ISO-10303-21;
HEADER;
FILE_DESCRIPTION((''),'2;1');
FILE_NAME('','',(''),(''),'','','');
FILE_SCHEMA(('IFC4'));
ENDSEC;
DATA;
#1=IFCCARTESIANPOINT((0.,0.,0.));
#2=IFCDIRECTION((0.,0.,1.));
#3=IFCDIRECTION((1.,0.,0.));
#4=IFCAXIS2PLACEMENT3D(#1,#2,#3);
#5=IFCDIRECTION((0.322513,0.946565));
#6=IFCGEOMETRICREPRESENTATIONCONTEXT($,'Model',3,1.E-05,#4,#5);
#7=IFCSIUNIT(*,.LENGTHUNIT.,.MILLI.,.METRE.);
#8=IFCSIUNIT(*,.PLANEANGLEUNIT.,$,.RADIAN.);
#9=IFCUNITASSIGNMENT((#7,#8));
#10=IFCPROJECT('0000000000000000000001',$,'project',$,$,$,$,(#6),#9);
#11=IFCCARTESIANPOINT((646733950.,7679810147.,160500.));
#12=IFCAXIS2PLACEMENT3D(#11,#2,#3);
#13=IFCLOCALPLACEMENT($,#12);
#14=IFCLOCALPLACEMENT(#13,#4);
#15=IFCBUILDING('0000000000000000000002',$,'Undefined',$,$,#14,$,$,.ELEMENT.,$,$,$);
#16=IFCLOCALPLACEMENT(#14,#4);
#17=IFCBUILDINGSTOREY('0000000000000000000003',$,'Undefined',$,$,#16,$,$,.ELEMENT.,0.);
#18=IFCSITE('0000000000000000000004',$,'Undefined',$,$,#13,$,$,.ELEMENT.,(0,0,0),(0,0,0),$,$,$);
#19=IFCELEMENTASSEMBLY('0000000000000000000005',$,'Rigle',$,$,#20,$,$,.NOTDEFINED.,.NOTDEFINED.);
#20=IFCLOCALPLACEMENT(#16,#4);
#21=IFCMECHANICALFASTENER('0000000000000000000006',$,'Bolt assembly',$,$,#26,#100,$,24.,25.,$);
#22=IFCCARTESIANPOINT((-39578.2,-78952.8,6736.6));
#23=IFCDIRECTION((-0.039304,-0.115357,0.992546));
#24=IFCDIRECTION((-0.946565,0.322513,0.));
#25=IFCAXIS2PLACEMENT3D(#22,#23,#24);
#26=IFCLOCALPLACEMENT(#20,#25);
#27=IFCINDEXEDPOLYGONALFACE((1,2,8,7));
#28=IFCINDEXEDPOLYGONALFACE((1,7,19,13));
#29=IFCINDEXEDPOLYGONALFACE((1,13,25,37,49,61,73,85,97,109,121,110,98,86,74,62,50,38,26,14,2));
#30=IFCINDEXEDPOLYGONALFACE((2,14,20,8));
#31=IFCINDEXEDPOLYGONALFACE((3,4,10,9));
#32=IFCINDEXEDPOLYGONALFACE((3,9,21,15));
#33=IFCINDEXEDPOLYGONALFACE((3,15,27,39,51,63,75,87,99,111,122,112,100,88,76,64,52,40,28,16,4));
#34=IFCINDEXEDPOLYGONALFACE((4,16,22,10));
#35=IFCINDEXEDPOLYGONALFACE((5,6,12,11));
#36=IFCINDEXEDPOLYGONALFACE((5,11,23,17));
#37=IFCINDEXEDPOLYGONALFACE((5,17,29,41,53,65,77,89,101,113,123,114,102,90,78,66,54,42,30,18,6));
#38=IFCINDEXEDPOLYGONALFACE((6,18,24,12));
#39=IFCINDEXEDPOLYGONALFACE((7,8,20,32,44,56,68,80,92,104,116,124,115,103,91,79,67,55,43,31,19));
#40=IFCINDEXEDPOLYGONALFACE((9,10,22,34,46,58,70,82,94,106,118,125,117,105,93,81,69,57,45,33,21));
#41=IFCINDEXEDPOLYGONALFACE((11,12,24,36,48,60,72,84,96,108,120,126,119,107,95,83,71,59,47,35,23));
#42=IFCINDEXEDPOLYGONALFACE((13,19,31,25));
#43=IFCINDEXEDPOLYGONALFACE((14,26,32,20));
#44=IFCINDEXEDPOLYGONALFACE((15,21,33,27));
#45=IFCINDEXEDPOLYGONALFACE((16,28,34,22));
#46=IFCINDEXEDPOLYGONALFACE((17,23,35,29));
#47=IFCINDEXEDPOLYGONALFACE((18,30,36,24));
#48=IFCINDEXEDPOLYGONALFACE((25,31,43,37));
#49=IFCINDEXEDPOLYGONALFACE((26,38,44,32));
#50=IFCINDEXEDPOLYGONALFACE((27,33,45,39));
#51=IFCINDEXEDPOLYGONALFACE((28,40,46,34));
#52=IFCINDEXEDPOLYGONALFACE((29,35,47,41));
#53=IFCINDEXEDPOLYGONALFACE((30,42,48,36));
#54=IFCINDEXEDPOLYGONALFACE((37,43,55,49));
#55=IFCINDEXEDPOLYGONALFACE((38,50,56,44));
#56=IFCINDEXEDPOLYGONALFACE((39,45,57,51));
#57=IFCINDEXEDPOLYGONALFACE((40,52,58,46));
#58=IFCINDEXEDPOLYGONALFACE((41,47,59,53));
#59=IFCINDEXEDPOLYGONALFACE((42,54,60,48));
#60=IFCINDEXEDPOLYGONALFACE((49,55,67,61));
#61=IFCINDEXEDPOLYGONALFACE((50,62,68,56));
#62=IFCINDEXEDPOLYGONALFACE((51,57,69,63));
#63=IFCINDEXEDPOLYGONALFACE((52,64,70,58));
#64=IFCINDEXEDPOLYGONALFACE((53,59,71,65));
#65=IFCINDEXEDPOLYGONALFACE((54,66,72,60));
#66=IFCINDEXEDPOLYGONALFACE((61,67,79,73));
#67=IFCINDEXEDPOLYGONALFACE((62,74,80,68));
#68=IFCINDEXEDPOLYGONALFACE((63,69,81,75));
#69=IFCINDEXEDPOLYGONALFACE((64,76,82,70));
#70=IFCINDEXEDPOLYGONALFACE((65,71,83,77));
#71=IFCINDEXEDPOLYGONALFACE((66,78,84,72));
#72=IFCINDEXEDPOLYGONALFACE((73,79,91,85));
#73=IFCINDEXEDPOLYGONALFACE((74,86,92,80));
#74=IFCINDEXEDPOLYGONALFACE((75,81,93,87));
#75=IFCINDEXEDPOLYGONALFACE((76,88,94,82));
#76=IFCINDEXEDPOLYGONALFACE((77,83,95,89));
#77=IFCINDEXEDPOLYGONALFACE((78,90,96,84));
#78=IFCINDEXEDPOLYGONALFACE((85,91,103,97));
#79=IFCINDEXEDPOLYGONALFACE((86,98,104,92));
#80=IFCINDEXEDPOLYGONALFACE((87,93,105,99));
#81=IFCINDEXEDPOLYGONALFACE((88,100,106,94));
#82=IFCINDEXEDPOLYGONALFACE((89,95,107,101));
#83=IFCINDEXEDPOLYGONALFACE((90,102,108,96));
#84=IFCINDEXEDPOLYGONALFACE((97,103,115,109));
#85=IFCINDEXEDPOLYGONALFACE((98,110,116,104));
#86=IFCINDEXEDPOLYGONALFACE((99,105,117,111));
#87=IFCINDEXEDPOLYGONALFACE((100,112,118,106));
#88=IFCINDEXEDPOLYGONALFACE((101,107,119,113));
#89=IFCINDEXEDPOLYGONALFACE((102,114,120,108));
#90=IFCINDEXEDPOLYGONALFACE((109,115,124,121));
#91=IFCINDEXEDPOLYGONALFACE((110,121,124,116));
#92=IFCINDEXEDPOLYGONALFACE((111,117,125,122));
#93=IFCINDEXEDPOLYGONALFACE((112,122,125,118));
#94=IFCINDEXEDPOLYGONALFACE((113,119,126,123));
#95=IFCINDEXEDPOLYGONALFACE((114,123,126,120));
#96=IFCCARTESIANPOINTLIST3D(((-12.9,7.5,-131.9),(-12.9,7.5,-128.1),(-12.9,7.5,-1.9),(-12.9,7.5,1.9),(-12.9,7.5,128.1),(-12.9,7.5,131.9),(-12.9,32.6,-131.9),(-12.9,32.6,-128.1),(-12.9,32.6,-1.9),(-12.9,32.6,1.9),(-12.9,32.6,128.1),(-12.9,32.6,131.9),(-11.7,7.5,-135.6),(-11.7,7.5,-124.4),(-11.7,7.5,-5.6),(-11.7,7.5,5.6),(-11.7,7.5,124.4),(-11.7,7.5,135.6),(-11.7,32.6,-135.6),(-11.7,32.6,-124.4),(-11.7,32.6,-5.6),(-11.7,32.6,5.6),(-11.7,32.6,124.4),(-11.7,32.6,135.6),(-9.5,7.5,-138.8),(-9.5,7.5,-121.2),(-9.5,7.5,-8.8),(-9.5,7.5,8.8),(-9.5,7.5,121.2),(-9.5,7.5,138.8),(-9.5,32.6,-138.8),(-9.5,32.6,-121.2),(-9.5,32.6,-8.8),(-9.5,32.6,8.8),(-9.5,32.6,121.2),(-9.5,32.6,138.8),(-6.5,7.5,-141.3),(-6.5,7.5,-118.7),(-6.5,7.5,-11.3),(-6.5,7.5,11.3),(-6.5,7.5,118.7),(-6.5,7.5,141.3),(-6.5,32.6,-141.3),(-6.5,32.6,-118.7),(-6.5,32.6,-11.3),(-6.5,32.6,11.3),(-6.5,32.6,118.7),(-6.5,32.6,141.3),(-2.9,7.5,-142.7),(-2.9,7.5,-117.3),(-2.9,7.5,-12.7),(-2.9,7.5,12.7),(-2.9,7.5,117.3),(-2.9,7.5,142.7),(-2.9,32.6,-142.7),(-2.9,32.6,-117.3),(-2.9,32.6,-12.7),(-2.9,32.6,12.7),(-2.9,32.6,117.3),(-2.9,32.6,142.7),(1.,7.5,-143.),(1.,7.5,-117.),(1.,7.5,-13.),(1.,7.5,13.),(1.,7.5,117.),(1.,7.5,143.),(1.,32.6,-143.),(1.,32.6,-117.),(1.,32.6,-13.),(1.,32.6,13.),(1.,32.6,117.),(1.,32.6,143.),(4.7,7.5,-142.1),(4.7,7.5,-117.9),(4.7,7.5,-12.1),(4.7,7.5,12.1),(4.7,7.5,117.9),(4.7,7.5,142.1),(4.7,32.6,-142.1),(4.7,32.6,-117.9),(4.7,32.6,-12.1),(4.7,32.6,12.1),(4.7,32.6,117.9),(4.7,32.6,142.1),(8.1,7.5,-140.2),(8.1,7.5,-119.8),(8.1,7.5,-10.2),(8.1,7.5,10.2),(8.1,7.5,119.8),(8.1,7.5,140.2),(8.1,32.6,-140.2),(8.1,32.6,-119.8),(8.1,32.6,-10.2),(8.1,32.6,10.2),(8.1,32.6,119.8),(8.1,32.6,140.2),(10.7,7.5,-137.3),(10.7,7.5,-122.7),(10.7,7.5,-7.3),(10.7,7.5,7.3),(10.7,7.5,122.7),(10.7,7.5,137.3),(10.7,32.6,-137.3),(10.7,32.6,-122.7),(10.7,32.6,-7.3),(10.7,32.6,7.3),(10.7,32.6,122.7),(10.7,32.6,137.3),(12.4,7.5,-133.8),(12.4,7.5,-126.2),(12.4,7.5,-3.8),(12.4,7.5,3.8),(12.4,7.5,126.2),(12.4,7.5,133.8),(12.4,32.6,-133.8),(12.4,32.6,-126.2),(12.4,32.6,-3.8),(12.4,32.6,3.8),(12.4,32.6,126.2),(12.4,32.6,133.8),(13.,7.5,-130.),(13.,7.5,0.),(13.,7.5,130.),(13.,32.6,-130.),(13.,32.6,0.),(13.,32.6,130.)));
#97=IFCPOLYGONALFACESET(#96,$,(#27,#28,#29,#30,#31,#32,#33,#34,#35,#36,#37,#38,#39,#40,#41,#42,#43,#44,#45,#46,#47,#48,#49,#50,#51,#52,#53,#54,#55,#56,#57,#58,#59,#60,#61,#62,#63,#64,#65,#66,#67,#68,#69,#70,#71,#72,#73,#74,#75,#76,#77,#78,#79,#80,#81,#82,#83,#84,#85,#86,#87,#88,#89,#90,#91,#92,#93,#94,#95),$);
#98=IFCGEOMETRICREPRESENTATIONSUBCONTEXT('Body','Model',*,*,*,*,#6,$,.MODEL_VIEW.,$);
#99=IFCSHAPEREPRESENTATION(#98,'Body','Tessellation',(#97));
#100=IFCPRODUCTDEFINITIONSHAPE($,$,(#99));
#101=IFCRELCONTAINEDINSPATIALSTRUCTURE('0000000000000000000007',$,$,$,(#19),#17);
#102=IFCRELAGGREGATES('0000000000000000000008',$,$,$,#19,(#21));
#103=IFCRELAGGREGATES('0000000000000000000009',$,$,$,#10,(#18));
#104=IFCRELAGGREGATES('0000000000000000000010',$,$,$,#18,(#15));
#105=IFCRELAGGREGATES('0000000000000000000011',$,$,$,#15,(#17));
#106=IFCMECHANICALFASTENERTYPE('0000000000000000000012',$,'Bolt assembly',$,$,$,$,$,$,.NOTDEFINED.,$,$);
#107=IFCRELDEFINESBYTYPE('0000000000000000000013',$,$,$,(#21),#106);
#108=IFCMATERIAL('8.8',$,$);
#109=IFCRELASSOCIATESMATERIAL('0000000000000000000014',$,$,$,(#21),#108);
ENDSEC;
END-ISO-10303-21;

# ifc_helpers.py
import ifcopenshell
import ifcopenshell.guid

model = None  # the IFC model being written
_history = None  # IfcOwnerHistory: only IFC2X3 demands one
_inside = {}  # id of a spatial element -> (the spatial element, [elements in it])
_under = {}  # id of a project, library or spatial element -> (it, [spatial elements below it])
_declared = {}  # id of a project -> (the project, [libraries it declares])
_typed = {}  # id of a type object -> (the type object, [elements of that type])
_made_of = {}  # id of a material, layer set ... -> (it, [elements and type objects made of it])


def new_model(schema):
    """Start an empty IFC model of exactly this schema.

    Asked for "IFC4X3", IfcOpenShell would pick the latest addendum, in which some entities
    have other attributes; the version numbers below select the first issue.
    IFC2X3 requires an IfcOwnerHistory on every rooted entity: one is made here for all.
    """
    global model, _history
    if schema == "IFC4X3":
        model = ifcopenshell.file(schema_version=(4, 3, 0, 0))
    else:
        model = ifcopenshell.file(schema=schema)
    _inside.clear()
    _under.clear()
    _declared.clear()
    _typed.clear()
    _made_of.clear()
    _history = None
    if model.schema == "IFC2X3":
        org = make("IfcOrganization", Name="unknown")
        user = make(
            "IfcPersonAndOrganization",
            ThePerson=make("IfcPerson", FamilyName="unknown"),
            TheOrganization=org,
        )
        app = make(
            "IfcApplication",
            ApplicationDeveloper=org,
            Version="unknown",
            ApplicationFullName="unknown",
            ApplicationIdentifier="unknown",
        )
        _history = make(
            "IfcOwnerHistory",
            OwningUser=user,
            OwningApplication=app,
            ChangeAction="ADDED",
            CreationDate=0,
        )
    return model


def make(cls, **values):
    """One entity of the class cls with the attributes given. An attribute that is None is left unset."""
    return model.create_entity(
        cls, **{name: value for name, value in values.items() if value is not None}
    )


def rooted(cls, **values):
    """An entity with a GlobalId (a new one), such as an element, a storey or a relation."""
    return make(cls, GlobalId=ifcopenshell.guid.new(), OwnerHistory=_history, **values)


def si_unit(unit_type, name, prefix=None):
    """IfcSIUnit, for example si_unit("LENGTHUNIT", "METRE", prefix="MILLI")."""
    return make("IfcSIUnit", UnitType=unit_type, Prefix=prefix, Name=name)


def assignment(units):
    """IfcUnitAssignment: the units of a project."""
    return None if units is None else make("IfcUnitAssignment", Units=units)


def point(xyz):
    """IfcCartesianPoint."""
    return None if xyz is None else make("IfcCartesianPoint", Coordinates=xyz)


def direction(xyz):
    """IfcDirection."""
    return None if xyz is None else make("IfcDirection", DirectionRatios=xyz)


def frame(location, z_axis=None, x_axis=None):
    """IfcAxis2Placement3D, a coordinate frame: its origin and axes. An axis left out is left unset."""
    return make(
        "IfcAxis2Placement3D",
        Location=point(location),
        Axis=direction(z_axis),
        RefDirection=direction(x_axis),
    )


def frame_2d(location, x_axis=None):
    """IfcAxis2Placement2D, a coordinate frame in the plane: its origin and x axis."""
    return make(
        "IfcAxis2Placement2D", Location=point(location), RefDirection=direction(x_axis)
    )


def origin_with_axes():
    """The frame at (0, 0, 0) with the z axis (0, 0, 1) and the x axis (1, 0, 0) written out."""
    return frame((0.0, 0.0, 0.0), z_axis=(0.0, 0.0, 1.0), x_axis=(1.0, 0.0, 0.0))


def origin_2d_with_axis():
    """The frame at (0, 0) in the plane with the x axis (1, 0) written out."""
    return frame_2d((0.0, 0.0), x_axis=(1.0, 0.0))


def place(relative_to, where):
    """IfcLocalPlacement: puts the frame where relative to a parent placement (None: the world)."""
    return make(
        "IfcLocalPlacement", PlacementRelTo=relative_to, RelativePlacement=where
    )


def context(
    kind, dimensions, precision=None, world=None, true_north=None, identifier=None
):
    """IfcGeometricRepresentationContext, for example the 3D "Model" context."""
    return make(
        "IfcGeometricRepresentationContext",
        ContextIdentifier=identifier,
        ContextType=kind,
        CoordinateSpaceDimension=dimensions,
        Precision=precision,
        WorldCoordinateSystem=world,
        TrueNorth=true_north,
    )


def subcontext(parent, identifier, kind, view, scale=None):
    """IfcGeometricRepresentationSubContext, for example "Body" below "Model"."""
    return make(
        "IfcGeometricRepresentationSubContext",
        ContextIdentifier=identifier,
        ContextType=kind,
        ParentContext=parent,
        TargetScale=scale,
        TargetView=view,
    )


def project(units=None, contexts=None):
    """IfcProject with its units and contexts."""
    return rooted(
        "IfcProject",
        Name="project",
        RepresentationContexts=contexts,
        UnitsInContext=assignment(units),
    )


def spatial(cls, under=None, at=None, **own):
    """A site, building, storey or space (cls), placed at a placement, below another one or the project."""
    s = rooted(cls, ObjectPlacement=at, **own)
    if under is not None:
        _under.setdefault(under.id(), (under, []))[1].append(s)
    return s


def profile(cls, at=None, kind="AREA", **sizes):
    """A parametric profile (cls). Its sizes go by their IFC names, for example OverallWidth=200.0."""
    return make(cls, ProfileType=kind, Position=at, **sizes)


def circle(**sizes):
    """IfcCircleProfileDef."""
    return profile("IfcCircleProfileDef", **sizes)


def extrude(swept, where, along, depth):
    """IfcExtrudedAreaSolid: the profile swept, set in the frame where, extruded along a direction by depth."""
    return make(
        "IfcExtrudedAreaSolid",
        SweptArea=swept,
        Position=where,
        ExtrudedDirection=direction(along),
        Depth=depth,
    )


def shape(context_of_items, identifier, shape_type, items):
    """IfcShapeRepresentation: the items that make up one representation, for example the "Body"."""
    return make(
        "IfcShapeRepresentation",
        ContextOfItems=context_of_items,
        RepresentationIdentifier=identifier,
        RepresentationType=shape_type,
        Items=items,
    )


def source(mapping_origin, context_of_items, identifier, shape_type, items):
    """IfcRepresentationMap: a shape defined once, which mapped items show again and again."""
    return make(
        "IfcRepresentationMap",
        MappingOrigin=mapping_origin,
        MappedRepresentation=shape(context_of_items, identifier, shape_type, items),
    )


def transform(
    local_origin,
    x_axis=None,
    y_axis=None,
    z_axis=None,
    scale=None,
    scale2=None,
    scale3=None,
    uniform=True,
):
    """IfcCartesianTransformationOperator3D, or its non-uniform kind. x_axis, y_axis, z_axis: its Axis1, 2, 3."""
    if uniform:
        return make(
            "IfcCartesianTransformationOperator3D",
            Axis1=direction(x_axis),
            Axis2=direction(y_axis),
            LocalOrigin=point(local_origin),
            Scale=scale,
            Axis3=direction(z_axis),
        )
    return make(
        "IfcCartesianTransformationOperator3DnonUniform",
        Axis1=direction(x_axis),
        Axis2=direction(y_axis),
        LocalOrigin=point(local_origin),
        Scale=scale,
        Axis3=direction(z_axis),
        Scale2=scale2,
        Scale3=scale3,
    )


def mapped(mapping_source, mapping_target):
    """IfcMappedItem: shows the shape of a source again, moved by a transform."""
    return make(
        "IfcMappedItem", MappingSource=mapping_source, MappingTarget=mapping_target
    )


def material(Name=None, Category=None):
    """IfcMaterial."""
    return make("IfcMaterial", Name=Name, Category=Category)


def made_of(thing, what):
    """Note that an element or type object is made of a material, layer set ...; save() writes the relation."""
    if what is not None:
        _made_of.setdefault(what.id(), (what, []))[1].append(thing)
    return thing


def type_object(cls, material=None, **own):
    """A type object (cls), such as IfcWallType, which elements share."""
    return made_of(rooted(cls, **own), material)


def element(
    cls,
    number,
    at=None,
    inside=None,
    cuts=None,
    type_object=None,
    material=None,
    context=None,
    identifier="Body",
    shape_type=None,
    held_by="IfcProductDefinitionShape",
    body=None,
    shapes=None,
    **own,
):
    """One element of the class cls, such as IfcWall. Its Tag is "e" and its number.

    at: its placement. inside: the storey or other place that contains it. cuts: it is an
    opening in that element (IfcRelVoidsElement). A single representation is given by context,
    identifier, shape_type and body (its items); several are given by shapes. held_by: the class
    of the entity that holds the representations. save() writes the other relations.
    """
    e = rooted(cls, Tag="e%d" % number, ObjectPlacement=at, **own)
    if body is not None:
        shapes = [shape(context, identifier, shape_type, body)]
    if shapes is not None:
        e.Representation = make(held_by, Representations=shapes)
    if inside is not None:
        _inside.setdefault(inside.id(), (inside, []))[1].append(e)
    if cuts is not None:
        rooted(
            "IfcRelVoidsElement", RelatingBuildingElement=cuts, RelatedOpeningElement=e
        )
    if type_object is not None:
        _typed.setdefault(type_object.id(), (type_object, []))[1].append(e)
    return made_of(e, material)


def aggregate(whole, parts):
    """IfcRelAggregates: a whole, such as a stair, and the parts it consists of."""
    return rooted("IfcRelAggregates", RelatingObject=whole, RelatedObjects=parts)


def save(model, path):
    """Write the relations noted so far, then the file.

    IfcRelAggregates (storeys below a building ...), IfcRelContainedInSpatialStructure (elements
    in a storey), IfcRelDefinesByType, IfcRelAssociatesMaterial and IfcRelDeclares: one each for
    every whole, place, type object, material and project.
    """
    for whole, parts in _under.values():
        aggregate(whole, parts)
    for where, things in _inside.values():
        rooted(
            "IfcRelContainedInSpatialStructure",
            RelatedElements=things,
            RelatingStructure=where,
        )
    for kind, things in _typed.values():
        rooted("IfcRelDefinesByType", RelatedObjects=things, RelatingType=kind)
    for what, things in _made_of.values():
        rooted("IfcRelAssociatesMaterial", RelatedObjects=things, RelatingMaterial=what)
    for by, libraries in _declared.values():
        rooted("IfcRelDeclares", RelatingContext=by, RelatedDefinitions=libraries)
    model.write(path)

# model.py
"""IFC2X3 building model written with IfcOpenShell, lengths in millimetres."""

from ifc_helpers import new_model, si_unit, direction, frame, origin_with_axes, origin_2d_with_axis, place, context, subcontext, project, spatial, circle, extrude, source, transform, mapped, material, type_object, element, aggregate, save


model = new_model("IFC2X3")

# Units and contexts
model_context = context("Model", 3, precision=1e-05, world=origin_with_axes(), true_north=direction((0.322513, 0.946565)))
body_context = subcontext(model_context, "Body", "Model", "MODEL_VIEW")
ifc_project = project(units=[si_unit("LENGTHUNIT", "METRE", prefix="MILLI"), si_unit("PLANEANGLEUNIT", "RADIAN")], contexts=[model_context])

# Site, building, storey
site_placement = place(None, frame((646733950.0, 7679810147.0, 160500.0), z_axis=(0.0, 0.0, 1.0), x_axis=(1.0, 0.0, 0.0)))
site = spatial("IfcSite", under=ifc_project, at=site_placement, Name="Undefined", CompositionType="ELEMENT", RefLatitude=(0, 0, 0), RefLongitude=(0, 0, 0))
building_placement = place(site_placement, origin_with_axes())
building = spatial("IfcBuilding", under=site, at=building_placement, Name="Undefined", CompositionType="ELEMENT")
storey_placement = place(building_placement, origin_with_axes())
storey = spatial("IfcBuildingStorey", under=building, at=storey_placement, Name="Undefined", CompositionType="ELEMENT", Elevation=0.0)

# Element assembly
assembly_1_placement = place(storey_placement, origin_with_axes())
assembly_1 = element("IfcElementAssembly", 1, at=assembly_1_placement, inside=storey, Name="Rigle", AssemblyPlace="NOTDEFINED", PredefinedType="NOTDEFINED")

# Mechanical fastener
mechanical_fastener_type = type_object("IfcMechanicalFastenerType", Name="Bolt assembly")
ifc_material_1 = material(Name="8.8")
shared_shape_1 = source(origin_with_axes(), body_context, "Body", "SweptSolid", [
    extrude(circle(Radius=13.0, at=origin_2d_with_axis()), frame((0.0, 7.5, 0.0), z_axis=(0.0, 1.0, 0.0), x_axis=(1.0, 0.0, 0.0)), (0.0, 0.0, 1.0), 25.1),
])
mechanical_fastener_1_placement = place(assembly_1_placement, frame((-39578.2, -78952.8, 6736.6), z_axis=(-0.039304, -0.115357, 0.992546), x_axis=(-0.946565, 0.322513, 0.0)))
mechanical_fastener_1 = element("IfcMechanicalFastener", 2, at=mechanical_fastener_1_placement, type_object=mechanical_fastener_type, material=ifc_material_1, Name="Bolt assembly", NominalDiameter=24.0, NominalLength=25.0, context=body_context, shape_type="MappedRepresentation", body=[
    mapped(shared_shape_1, transform((0.0, 0.0, -130.0))),
    mapped(shared_shape_1, transform((0.0, 0.0, 0.0))),
    mapped(shared_shape_1, transform((0.0, 0.0, 130.0))),
])
aggregate(assembly_1, [mechanical_fastener_1])

save(model, "model.ifc")
